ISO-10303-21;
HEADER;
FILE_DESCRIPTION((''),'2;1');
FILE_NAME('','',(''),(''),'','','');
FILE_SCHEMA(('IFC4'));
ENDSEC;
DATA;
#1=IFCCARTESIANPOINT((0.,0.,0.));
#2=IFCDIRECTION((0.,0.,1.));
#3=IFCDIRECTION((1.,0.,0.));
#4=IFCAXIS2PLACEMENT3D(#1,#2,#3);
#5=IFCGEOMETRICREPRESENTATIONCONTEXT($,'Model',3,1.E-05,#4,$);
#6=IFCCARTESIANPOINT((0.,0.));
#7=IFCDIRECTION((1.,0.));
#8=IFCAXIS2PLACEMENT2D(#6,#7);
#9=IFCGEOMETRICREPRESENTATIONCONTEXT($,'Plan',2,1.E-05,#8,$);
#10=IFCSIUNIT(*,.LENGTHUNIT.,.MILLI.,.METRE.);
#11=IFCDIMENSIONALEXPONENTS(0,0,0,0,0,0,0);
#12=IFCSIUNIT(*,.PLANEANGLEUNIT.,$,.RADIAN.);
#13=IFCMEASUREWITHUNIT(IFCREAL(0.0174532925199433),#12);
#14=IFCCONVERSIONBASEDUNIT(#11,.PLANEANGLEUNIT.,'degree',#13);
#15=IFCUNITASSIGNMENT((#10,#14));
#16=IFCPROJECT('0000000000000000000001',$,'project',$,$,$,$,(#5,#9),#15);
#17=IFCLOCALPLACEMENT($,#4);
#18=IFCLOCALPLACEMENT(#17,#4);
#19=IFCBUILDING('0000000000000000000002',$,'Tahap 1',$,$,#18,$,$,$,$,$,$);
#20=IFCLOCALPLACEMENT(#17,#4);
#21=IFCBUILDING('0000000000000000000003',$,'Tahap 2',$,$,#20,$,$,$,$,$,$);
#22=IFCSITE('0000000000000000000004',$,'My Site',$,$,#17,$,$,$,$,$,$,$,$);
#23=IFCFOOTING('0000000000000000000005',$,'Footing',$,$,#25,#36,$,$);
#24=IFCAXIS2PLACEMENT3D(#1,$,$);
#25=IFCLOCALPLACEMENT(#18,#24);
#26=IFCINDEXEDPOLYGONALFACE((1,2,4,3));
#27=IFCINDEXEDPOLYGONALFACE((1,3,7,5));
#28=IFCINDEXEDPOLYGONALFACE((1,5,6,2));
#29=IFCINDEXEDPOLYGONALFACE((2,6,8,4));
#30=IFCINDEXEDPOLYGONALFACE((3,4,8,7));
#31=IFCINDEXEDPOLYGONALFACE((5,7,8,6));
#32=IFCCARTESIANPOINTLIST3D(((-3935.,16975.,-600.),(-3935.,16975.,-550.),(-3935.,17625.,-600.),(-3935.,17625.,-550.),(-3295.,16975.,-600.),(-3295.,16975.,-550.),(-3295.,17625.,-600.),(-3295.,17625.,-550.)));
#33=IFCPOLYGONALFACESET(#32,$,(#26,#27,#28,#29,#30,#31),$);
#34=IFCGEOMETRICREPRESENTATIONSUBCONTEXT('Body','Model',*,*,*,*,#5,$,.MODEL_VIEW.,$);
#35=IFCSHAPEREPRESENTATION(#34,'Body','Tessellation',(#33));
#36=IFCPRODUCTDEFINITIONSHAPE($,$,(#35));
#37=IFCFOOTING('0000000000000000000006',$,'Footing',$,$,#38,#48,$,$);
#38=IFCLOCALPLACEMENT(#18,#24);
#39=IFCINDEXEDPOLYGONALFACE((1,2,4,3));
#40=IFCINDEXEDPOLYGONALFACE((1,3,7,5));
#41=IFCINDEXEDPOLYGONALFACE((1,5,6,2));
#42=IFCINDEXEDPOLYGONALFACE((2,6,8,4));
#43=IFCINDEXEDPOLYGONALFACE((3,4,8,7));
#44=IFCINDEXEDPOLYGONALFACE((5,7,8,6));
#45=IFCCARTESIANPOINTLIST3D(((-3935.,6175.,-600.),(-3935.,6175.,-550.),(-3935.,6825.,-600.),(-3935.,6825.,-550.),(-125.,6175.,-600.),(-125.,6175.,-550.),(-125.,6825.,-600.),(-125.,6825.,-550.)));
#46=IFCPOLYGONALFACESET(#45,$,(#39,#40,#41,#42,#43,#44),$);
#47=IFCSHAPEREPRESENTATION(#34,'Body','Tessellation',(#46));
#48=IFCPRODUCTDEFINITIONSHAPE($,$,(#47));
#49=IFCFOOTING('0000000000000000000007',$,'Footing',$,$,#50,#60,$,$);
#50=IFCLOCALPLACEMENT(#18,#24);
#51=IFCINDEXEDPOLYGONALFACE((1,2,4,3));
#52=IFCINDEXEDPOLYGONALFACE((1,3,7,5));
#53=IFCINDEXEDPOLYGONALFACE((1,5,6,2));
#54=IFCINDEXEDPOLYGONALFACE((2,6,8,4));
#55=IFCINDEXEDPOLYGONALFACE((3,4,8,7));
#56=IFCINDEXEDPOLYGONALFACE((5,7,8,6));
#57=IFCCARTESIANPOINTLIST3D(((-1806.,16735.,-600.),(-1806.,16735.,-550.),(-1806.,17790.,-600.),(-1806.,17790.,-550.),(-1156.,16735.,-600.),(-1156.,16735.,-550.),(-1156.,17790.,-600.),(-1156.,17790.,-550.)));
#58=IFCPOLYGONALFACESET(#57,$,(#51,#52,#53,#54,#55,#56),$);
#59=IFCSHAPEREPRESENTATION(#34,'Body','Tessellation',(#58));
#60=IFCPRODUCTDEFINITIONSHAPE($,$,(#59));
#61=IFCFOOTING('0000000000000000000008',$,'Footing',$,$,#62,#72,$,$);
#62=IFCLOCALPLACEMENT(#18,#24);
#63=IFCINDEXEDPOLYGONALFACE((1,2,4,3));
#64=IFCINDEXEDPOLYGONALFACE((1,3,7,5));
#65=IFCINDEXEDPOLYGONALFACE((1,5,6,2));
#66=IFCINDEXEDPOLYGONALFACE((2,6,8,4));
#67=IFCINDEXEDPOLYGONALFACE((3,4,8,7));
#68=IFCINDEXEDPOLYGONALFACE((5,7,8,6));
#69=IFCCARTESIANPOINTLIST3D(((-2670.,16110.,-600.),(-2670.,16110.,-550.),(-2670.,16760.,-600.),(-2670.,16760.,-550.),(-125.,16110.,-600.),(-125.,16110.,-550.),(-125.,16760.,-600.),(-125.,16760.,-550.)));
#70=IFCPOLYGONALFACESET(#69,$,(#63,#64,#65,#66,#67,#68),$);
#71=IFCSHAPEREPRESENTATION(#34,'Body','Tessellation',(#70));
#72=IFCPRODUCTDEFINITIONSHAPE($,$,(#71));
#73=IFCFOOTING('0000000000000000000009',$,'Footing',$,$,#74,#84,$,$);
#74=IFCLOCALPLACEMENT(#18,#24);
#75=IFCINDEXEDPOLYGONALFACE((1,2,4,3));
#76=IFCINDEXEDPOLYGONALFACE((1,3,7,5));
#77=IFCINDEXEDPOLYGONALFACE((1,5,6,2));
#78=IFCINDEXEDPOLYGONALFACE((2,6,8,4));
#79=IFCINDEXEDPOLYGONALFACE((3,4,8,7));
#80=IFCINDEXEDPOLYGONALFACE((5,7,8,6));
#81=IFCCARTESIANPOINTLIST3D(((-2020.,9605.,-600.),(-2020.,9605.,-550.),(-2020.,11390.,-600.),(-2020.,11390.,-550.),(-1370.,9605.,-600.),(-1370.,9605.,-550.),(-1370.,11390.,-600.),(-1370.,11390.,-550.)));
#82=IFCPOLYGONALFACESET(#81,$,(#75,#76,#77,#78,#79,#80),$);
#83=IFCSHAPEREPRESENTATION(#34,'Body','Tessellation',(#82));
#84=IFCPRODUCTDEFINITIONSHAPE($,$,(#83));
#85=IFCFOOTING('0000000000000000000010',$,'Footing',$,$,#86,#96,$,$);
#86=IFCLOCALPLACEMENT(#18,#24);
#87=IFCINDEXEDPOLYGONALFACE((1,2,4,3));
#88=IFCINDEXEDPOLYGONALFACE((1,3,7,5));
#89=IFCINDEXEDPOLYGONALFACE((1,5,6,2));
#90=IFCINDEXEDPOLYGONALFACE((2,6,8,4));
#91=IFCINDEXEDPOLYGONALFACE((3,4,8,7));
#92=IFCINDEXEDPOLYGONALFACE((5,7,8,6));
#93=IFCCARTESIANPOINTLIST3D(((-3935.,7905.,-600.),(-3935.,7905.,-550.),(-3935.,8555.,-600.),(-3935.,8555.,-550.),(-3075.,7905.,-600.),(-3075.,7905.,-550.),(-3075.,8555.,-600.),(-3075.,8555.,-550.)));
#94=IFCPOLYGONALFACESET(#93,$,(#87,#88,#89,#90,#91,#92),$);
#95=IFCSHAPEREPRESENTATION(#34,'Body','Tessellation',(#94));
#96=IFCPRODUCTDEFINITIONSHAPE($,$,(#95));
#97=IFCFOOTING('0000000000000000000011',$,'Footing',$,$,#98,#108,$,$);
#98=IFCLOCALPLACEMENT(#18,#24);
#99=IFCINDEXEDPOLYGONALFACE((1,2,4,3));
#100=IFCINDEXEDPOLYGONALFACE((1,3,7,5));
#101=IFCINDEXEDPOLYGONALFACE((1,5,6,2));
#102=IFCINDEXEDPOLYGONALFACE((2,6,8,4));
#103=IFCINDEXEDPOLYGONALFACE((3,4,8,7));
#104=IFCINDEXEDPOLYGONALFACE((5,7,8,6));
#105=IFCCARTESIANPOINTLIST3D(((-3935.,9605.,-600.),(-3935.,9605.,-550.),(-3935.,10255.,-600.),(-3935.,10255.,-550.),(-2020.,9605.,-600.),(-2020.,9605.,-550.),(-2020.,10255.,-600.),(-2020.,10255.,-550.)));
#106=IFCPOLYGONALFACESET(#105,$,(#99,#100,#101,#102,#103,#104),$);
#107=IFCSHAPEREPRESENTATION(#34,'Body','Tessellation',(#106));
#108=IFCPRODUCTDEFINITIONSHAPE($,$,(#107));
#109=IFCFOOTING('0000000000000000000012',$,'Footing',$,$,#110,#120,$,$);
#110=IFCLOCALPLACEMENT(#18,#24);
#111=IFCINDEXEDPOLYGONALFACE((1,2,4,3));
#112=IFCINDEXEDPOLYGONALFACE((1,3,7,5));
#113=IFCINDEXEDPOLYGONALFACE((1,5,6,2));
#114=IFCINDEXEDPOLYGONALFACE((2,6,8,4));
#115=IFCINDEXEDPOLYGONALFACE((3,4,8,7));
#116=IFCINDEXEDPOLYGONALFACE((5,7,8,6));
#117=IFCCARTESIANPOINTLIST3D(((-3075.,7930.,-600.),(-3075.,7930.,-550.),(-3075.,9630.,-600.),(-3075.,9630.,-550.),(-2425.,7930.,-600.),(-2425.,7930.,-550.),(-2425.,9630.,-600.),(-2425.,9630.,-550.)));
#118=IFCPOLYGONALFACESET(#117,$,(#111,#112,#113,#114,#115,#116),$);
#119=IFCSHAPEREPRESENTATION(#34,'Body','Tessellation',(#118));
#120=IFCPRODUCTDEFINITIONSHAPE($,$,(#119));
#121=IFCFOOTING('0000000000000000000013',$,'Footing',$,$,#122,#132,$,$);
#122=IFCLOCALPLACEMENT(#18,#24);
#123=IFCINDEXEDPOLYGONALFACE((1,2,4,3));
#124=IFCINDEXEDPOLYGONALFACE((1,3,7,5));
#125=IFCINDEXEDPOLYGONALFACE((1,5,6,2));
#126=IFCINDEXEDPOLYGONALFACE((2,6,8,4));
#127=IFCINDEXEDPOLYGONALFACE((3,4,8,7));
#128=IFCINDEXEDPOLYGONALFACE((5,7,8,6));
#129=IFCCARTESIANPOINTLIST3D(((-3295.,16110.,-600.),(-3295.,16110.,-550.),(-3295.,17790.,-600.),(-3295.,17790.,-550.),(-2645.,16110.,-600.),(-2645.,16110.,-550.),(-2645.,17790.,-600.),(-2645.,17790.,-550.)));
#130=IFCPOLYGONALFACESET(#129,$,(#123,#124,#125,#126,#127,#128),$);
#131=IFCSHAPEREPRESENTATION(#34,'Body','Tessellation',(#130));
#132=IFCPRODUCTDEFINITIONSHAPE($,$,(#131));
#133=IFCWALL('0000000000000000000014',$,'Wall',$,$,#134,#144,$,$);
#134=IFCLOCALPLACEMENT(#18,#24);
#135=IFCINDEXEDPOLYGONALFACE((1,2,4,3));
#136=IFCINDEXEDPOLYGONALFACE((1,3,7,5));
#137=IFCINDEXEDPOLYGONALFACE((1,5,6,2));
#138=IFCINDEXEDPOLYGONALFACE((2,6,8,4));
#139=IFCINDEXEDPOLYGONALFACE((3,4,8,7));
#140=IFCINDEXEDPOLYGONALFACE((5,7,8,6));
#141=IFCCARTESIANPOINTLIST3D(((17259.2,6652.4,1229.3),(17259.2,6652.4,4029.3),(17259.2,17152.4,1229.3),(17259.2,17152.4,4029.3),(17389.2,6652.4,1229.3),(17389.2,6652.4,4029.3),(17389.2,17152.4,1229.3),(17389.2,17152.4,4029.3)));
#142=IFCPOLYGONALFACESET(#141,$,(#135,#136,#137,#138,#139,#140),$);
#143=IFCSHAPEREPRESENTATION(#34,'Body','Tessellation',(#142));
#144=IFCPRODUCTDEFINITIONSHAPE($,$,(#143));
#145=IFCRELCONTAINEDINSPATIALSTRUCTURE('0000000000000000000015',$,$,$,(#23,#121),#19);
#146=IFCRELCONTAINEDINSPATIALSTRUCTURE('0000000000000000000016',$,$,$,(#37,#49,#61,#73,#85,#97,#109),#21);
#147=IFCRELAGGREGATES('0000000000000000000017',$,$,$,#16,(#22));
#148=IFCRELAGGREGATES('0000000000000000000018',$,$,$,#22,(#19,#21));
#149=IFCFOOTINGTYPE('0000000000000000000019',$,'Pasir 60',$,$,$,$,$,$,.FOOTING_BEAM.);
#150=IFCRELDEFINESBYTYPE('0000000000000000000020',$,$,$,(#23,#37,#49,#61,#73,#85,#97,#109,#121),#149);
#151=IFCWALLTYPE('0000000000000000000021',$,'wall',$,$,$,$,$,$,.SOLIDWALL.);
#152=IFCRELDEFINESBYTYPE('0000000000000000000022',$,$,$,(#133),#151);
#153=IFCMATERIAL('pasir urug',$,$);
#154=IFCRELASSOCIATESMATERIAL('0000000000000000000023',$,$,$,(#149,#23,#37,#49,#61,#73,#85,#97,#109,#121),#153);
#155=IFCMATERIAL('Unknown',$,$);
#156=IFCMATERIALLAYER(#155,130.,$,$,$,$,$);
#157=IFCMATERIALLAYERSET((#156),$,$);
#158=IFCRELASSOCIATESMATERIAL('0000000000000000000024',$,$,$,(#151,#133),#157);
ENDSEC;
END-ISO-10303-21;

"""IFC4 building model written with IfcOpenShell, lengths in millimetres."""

from ifc_helpers import new_model, entity, si_unit, converted_unit, frame, origin_with_axes, origin_2d_with_axis, place, context, subcontext, project, spatial, line, indexed_curve, rectangle, outline, extrude, material, layer, layer_set, layer_usage, material_profile, profile_set, profile_usage, type_object, element, save


model = new_model("IFC4")

# Units and contexts
model_context = context("Model", 3, precision=1e-05, world=origin_with_axes())
plan_context = context("Plan", 2, precision=1e-05, world=origin_2d_with_axis())
body_context = subcontext(model_context, "Body", "Model", "MODEL_VIEW")
ifc_project = project(units=[si_unit("LENGTHUNIT", "METRE", prefix="MILLI"), converted_unit("PLANEANGLEUNIT", "degree", entity("IfcReal", 0.0174532925199433), si_unit("PLANEANGLEUNIT", "RADIAN"), dimensions=[0, 0, 0, 0, 0, 0, 0])], contexts=[model_context, plan_context])

# Site, building
site_placement = place(None, origin_with_axes())
site = spatial("IfcSite", under=ifc_project, at=site_placement, Name="My Site")
building_1_placement = place(site_placement, origin_with_axes())
building_1 = spatial("IfcBuilding", under=site, at=building_1_placement, Name="Tahap 1")

# Shared definitions
ifc_material_1 = material(Name="Unknown")

# Shared definitions
building_2_placement = place(site_placement, origin_with_axes())
building_2 = spatial("IfcBuilding", under=site, at=building_2_placement, Name="Tahap 2")

# Footings
ifc_material_2 = material(Name="pasir urug")
ifc_material_profile_1 = material_profile(ifc_material_2, rectangle(XDim=650.0, YDim=50.0, kind="CURVE"))
ifc_profile_set_1 = profile_set([ifc_material_profile_1])
footing_type_1 = type_object("IfcFootingType", Name="Pasir 60", PredefinedType="FOOTING_BEAM", material=ifc_profile_set_1)
ifc_profile_usage_1 = profile_usage(ifc_profile_set_1, cardinal=8)
footing_1_placement = place(building_1_placement, frame((-3295.0, 17300.0, -550.0), z_axis=(-1.0, 0.0, 0.0), x_axis=(0.0, -1.0, 0.0)))
element("IfcFooting", 1, at=footing_1_placement, inside=building_1, type_object=footing_type_1, material=ifc_profile_usage_1, Name="Footing", context=body_context, shape_type="SweptSolid", body=[
    extrude(rectangle(XDim=650.0, YDim=50.0, kind="CURVE"), frame((0.0, -25.0, 0.0), z_axis=(0.0, 0.0, 1.0), x_axis=(1.0, 0.0, 0.0)), (0.0, 0.0, 1.0), 640.0),
])
ifc_profile_usage_2 = profile_usage(ifc_profile_set_1, cardinal=8)
footing_2_placement = place(building_2_placement, frame((-3935.0, 6500.0, -550.0), z_axis=(1.0, 0.0, 0.0), x_axis=(0.0, 1.0, 0.0)))
element("IfcFooting", 2, at=footing_2_placement, inside=building_2, type_object=footing_type_1, material=ifc_profile_usage_2, Name="Footing", context=body_context, shape_type="SweptSolid", body=[
    extrude(rectangle(XDim=650.0, YDim=50.0, kind="CURVE"), frame((0.0, -25.0, 0.0), z_axis=(0.0, 0.0, 1.0), x_axis=(1.0, 0.0, 0.0)), (0.0, 0.0, 1.0), 3810.0),
])
ifc_profile_usage_3 = profile_usage(ifc_profile_set_1, cardinal=8)
footing_3_placement = place(building_2_placement, frame((-1481.0, 16735.0, -550.0), z_axis=(0.0, 1.0, 0.0), x_axis=(-1.0, 0.0, 0.0)))
element("IfcFooting", 3, at=footing_3_placement, inside=building_2, type_object=footing_type_1, material=ifc_profile_usage_3, Name="Footing", context=body_context, shape_type="SweptSolid", body=[
    extrude(rectangle(XDim=650.0, YDim=50.0, kind="CURVE"), frame((0.0, -25.0, 0.0), z_axis=(0.0, 0.0, 1.0), x_axis=(1.0, 0.0, 0.0)), (0.0, 0.0, 1.0), 1055.0),
])
ifc_profile_usage_4 = profile_usage(ifc_profile_set_1, cardinal=8)
footing_4_placement = place(building_2_placement, frame((-125.0, 16435.0, -550.0), z_axis=(-1.0, 0.0, 0.0), x_axis=(0.0, -1.0, 0.0)))
element("IfcFooting", 4, at=footing_4_placement, inside=building_2, type_object=footing_type_1, material=ifc_profile_usage_4, Name="Footing", context=body_context, shape_type="SweptSolid", body=[
    extrude(rectangle(XDim=650.0, YDim=50.0, kind="CURVE"), frame((0.0, -25.0, 0.0), z_axis=(0.0, 0.0, 1.0), x_axis=(1.0, 0.0, 0.0)), (0.0, 0.0, 1.0), 2545.0),
])
ifc_profile_usage_5 = profile_usage(ifc_profile_set_1, cardinal=8)
footing_5_placement = place(building_2_placement, frame((-1695.0, 11390.0, -550.0), z_axis=(0.0, -1.0, 0.0), x_axis=(1.0, 0.0, 0.0)))
element("IfcFooting", 5, at=footing_5_placement, inside=building_2, type_object=footing_type_1, material=ifc_profile_usage_5, Name="Footing", context=body_context, shape_type="SweptSolid", body=[
    extrude(rectangle(XDim=650.0, YDim=50.0, kind="CURVE"), frame((0.0, -25.0, 0.0), z_axis=(0.0, 0.0, 1.0), x_axis=(1.0, 0.0, 0.0)), (0.0, 0.0, 1.0), 1785.0),
])
ifc_profile_usage_6 = profile_usage(ifc_profile_set_1, cardinal=8)
footing_6_placement = place(building_2_placement, frame((-3935.0, 8230.0, -550.0), z_axis=(1.0, 0.0, 0.0), x_axis=(0.0, 1.0, 0.0)))
element("IfcFooting", 6, at=footing_6_placement, inside=building_2, type_object=footing_type_1, material=ifc_profile_usage_6, Name="Footing", context=body_context, shape_type="SweptSolid", body=[
    extrude(rectangle(XDim=650.0, YDim=50.0, kind="CURVE"), frame((0.0, -25.0, 0.0), z_axis=(0.0, 0.0, 1.0), x_axis=(1.0, 0.0, 0.0)), (0.0, 0.0, 1.0), 860.0),
])
ifc_profile_usage_7 = profile_usage(ifc_profile_set_1, cardinal=8)
footing_7_placement = place(building_2_placement, frame((-2020.0, 9930.0, -550.0), z_axis=(-1.0, 0.0, 0.0), x_axis=(0.0, -1.0, 0.0)))
element("IfcFooting", 7, at=footing_7_placement, inside=building_2, type_object=footing_type_1, material=ifc_profile_usage_7, Name="Footing", context=body_context, shape_type="SweptSolid", body=[
    extrude(rectangle(XDim=650.0, YDim=50.0, kind="CURVE"), frame((0.0, -25.0, 0.0), z_axis=(0.0, 0.0, 1.0), x_axis=(1.0, 0.0, 0.0)), (0.0, 0.0, 1.0), 1915.0),
])
ifc_profile_usage_8 = profile_usage(ifc_profile_set_1, cardinal=8)
footing_8_placement = place(building_2_placement, frame((-2750.0, 7930.0, -550.0), z_axis=(0.0, 1.0, 0.0), x_axis=(-1.0, 0.0, 0.0)))
element("IfcFooting", 8, at=footing_8_placement, inside=building_2, type_object=footing_type_1, material=ifc_profile_usage_8, Name="Footing", context=body_context, shape_type="SweptSolid", body=[
    extrude(rectangle(XDim=650.0, YDim=50.0, kind="CURVE"), frame((0.0, -25.0, 0.0), z_axis=(0.0, 0.0, 1.0), x_axis=(1.0, 0.0, 0.0)), (0.0, 0.0, 1.0), 1700.0),
])
ifc_profile_usage_9 = profile_usage(ifc_profile_set_1, cardinal=8)
footing_9_placement = place(building_1_placement, frame((-2970.0, 16110.0, -550.0), z_axis=(0.0, 1.0, 0.0), x_axis=(-1.0, 0.0, 0.0)))
element("IfcFooting", 9, at=footing_9_placement, inside=building_1, type_object=footing_type_1, material=ifc_profile_usage_9, Name="Footing", context=body_context, shape_type="SweptSolid", body=[
    extrude(rectangle(XDim=650.0, YDim=50.0, kind="CURVE"), frame((0.0, -25.0, 0.0), z_axis=(0.0, 0.0, 1.0), x_axis=(1.0, 0.0, 0.0)), (0.0, 0.0, 1.0), 1680.0),
])

# Wall
ifc_layer = layer(ifc_material_1, 130.0)
ifc_layer_set = layer_set([ifc_layer])
wall_type = type_object("IfcWallType", Name="wall", PredefinedType="SOLIDWALL", material=ifc_layer_set)
placement_1 = place(building_2_placement, frame((0.0, 0.0, 200.0), z_axis=(0.0, 0.0, 1.0), x_axis=(1.0, 0.0, 0.0)))
placement_2 = place(placement_1, frame((17259.2, 6652.4, 1029.3), z_axis=(0.0, 0.0, 1.0), x_axis=(1.0, 0.0, 0.0)))
ifc_layer_usage_1 = layer_usage(ifc_layer_set, "AXIS2", "NEGATIVE", 0.0)
wall_1_placement = place(placement_2, frame((0.0, 0.0, 0.0), z_axis=(0.0, 0.0, 1.0), x_axis=(0.0, 1.0, 0.0)))
element("IfcWall", 10, at=wall_1_placement, type_object=wall_type, material=ifc_layer_usage_1, Name="Wall", context=body_context, shape_type="SweptSolid", body=[
    extrude(outline(indexed_curve([(0.0, -130.0), (0.0, 0.0), (10500.0, 0.0), (10500.0, -130.0)], segments=[line(1, 2, 3, 4, 1)])), origin_with_axes(), (0.0, 0.0, 1.0), 2800.0),
])

save(model, "model.ifc")
